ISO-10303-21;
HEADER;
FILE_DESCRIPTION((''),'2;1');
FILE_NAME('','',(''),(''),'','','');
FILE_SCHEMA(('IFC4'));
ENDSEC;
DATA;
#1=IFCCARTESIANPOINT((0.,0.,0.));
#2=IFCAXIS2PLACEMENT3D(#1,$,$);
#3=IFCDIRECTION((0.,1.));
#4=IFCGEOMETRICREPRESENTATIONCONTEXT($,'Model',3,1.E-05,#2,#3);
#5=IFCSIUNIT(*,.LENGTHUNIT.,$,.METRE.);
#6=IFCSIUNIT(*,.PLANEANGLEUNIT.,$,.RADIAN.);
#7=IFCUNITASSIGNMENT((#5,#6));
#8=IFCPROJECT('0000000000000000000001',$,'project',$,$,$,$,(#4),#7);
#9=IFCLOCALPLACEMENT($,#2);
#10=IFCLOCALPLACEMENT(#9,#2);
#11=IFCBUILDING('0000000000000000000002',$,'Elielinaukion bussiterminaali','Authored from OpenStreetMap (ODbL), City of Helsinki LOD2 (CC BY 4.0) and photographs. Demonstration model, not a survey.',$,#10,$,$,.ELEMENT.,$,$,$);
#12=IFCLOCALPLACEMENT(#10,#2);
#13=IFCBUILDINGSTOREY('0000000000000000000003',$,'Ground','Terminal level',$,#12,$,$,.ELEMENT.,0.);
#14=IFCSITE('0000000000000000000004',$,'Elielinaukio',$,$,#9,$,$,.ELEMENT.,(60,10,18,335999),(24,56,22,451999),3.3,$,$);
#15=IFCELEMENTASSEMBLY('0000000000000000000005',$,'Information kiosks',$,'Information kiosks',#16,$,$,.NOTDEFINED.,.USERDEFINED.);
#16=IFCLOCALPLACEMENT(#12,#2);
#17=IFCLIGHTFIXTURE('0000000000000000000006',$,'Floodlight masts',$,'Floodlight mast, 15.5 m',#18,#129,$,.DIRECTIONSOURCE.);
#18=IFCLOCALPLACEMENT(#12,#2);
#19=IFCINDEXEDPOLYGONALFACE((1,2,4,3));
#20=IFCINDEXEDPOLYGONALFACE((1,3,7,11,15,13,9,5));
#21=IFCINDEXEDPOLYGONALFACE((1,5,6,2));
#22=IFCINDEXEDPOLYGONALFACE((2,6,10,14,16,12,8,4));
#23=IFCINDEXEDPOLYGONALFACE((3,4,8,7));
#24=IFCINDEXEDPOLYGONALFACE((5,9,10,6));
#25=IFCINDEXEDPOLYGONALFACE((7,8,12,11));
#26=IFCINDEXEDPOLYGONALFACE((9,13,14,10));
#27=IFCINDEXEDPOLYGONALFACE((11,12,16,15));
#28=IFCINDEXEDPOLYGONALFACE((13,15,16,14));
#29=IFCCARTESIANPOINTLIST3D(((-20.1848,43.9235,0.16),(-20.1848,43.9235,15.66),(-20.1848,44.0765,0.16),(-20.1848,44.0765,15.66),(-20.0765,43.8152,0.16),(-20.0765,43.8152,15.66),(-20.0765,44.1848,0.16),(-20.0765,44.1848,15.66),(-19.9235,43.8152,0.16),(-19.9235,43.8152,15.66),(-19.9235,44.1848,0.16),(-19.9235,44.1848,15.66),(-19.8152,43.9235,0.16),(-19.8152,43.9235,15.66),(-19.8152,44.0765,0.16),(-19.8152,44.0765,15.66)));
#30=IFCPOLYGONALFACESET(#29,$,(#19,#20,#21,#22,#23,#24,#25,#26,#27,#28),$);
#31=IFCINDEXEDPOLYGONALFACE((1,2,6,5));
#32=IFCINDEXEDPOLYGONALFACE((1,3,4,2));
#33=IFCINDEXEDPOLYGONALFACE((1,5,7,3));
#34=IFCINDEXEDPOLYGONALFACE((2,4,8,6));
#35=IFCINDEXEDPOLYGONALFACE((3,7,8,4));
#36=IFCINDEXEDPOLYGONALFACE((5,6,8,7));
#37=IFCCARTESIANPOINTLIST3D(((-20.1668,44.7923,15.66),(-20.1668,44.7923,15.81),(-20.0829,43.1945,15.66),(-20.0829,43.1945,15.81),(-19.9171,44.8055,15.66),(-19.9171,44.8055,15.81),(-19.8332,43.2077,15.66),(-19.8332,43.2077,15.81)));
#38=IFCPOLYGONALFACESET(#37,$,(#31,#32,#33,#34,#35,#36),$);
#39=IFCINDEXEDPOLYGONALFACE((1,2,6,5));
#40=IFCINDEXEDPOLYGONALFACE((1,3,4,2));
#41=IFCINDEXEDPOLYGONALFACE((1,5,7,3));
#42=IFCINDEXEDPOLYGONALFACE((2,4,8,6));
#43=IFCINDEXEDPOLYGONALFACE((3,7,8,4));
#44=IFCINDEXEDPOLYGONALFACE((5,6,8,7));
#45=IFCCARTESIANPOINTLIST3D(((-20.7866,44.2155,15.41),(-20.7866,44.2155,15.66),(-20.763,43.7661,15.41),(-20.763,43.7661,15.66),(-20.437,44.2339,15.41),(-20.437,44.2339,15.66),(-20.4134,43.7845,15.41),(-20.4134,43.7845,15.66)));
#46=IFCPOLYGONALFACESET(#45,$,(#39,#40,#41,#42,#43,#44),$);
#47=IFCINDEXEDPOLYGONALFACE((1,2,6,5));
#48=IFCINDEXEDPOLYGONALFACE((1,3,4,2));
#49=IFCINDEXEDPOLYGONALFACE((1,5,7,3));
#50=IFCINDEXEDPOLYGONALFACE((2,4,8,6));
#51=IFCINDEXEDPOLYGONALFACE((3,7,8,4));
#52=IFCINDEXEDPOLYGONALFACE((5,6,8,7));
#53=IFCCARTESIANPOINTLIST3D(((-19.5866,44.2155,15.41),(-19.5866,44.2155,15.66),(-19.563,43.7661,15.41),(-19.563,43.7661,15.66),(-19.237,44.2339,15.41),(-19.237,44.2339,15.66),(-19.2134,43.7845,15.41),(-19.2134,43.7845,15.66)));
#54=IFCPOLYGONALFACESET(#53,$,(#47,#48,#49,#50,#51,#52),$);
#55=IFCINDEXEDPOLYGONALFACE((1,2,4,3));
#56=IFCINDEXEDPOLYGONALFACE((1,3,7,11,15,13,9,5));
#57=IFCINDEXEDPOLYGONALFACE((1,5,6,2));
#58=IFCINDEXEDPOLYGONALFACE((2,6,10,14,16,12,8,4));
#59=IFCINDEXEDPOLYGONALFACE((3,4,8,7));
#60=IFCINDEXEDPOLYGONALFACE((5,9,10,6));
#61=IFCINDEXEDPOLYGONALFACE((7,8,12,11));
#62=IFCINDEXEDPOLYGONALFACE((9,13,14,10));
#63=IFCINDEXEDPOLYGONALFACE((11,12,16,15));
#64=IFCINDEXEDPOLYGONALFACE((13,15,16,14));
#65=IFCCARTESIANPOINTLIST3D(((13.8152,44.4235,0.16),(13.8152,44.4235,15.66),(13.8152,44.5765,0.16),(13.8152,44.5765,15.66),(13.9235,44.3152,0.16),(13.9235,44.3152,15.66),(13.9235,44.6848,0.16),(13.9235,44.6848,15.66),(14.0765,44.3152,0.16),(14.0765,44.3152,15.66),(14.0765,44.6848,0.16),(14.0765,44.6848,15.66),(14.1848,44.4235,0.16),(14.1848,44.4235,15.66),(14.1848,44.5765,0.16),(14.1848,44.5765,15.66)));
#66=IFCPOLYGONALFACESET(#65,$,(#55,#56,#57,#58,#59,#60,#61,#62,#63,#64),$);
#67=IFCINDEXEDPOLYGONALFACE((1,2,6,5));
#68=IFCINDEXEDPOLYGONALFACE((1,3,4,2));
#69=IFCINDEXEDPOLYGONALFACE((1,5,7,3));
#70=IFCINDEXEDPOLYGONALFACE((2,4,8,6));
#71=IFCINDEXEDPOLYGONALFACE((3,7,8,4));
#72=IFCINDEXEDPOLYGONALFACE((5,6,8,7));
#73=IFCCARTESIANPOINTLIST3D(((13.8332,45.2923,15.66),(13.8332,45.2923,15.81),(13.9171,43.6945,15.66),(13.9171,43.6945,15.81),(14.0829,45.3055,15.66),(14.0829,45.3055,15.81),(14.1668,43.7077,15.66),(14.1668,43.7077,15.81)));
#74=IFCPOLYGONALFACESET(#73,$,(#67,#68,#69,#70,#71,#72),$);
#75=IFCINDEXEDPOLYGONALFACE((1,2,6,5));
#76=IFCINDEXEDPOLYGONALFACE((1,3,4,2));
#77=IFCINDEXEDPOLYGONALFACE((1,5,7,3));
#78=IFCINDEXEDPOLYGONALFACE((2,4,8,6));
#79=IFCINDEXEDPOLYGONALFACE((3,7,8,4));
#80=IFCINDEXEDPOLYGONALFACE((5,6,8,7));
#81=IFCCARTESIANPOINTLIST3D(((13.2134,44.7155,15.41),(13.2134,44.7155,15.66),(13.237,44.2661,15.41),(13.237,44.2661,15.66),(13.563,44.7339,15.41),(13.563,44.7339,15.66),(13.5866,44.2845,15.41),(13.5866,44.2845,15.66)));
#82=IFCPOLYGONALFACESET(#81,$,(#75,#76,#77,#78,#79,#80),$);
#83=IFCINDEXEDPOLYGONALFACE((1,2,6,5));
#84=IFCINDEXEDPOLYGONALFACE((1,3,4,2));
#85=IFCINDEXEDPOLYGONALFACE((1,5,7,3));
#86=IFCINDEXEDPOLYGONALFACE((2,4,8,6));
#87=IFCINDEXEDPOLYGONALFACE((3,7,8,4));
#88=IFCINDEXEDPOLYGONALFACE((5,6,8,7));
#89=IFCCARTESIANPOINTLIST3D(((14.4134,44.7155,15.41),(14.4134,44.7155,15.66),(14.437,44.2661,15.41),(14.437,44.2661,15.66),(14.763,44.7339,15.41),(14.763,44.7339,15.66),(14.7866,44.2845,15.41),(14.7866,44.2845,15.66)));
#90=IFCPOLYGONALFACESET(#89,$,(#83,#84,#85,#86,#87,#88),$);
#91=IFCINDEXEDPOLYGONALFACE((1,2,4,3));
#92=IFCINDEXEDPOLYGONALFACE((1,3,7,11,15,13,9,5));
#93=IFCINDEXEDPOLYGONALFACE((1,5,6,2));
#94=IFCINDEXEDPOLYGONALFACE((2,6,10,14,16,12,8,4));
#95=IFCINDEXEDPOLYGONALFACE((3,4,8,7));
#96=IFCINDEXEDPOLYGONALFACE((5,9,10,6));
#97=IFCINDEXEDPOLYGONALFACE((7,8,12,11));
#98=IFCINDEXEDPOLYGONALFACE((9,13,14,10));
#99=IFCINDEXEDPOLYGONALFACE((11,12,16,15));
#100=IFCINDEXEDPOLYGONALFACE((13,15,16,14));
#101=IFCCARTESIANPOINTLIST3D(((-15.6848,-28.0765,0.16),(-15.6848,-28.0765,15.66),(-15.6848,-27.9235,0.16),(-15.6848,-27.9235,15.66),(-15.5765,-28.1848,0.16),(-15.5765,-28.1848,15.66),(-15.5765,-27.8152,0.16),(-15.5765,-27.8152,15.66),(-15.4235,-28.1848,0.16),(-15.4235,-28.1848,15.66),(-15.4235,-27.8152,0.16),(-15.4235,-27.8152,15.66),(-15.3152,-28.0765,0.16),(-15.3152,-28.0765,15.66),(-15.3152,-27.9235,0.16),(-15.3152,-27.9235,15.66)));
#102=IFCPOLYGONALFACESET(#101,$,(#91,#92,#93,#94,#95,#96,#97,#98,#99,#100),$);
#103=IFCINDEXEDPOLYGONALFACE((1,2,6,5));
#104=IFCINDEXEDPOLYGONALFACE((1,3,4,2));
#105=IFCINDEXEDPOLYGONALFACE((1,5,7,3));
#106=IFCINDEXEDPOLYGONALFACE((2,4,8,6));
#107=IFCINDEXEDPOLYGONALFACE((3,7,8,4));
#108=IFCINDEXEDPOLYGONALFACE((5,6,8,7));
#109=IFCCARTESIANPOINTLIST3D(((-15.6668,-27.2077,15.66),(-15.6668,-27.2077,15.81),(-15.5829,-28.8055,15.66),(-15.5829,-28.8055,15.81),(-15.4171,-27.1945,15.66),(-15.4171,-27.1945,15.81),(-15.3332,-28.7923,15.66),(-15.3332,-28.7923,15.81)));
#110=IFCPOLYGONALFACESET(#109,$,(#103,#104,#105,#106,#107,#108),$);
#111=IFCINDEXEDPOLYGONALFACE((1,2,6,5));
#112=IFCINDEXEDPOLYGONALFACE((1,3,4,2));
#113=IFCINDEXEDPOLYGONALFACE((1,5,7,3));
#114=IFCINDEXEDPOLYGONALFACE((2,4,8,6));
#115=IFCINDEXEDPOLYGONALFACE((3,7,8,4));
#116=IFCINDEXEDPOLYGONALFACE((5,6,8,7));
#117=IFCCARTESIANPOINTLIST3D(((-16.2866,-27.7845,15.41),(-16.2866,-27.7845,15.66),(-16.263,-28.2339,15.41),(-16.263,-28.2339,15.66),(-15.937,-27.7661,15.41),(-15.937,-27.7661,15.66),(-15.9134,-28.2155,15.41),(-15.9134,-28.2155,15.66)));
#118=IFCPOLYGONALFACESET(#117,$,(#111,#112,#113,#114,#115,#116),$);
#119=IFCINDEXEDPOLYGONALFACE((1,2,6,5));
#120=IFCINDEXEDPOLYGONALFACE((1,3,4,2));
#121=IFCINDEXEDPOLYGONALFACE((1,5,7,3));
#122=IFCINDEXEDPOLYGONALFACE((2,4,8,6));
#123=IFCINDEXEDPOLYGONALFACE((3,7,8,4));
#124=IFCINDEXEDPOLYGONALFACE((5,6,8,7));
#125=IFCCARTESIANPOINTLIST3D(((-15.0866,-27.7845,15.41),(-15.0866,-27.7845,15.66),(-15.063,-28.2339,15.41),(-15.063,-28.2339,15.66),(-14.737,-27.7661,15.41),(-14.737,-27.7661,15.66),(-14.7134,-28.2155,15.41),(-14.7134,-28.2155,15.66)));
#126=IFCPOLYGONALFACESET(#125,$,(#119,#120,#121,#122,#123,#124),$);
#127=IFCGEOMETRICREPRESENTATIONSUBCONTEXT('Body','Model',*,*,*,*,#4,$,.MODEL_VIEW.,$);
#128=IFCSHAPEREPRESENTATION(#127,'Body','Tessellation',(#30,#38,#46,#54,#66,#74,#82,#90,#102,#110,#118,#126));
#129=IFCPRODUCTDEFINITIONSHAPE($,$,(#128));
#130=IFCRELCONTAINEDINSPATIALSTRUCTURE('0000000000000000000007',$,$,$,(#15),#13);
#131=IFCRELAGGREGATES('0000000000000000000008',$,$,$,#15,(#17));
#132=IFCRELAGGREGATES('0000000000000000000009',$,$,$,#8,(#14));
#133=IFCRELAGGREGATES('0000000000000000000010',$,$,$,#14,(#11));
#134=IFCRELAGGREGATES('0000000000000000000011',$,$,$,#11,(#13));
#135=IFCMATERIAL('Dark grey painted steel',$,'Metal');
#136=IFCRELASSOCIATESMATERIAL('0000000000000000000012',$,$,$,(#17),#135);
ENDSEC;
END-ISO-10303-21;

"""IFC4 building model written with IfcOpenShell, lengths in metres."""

from ifc_helpers import new_model, si_unit, direction, frame, frame_2d, origin, place, context, subcontext, project, spatial, polyline, rectangle, outline, extrude, material, element, aggregate, save


model = new_model("IFC4")

# Units and contexts
model_context = context("Model", 3, precision=1e-05, world=origin(), true_north=direction((0.0, 1.0)))
body_context = subcontext(model_context, "Body", "Model", "MODEL_VIEW")
ifc_project = project(units=[si_unit("LENGTHUNIT", "METRE"), si_unit("PLANEANGLEUNIT", "RADIAN")], contexts=[model_context])

# Site, building, storey
site_placement = place(None, origin())
site = spatial("IfcSite", under=ifc_project, at=site_placement, Name="Elielinaukio", CompositionType="ELEMENT", RefLatitude=(60, 10, 18, 335999), RefLongitude=(24, 56, 22, 451999), RefElevation=3.3)
building_placement = place(site_placement, origin())
building = spatial("IfcBuilding", under=site, at=building_placement, Name="Elielinaukion bussiterminaali", Description="Authored from OpenStreetMap (ODbL), City of Helsinki LOD2 (CC BY 4.0) and photographs. Demonstration model, not a survey.", CompositionType="ELEMENT")
storey_placement = place(building_placement, origin())
storey = spatial("IfcBuildingStorey", under=building, at=storey_placement, Name="Ground", Description="Terminal level", CompositionType="ELEMENT", Elevation=0.0)

# Shared definitions
ifc_material_1 = material(Name="Dark grey painted steel", Category="Metal")

# Element assembly, light fixture
assembly_1_placement = place(building_placement, origin())
assembly_1 = element("IfcElementAssembly", 1, at=assembly_1_placement, inside=storey, Name="Information kiosks", ObjectType="Information kiosks", AssemblyPlace="NOTDEFINED", PredefinedType="USERDEFINED")
light_fixture_1_placement = place(building_placement, origin())
light_fixture_1 = element("IfcLightFixture", 2, at=light_fixture_1_placement, material=ifc_material_1, Name="Floodlight masts", ObjectType="Floodlight mast, 15.5 m", PredefinedType="DIRECTIONSOURCE", context=body_context, shape_type="SweptSolid", body=[
    extrude(outline(polyline([(-19.8152, 44.0765), (-19.9235, 44.1848), (-20.0765, 44.1848), (-20.1848, 44.0765), (-20.1848, 43.9235), (-20.0765, 43.8152), (-19.9235, 43.8152), (-19.8152, 43.9235), (-19.8152, 44.0765)])), frame((0.0, 0.0, 0.16)), (0.0, 0.0, 1.0), 15.5),
    extrude(rectangle(XDim=1.6, YDim=0.25, at=frame_2d((0.0, 0.0), x_axis=(-0.052408, 0.998626))), frame((-20.0, 44.0, 15.66)), (0.0, 0.0, 1.0), 0.15),
    extrude(rectangle(XDim=0.45, YDim=0.35, at=frame_2d((0.0, 0.0), x_axis=(-0.052408, 0.998626))), frame((-20.6, 44.0, 15.41)), (0.0, 0.0, 1.0), 0.25),
    extrude(rectangle(XDim=0.45, YDim=0.35, at=frame_2d((0.0, 0.0), x_axis=(-0.052408, 0.998626))), frame((-19.4, 44.0, 15.41)), (0.0, 0.0, 1.0), 0.25),
    extrude(outline(polyline([(14.1848, 44.5765), (14.0765, 44.6848), (13.9235, 44.6848), (13.8152, 44.5765), (13.8152, 44.4235), (13.9235, 44.3152), (14.0765, 44.3152), (14.1848, 44.4235), (14.1848, 44.5765)])), frame((0.0, 0.0, 0.16)), (0.0, 0.0, 1.0), 15.5),
    extrude(rectangle(XDim=1.6, YDim=0.25, at=frame_2d((0.0, 0.0), x_axis=(-0.052408, 0.998626))), frame((14.0, 44.5, 15.66)), (0.0, 0.0, 1.0), 0.15),
    extrude(rectangle(XDim=0.45, YDim=0.35, at=frame_2d((0.0, 0.0), x_axis=(-0.052408, 0.998626))), frame((13.4, 44.5, 15.41)), (0.0, 0.0, 1.0), 0.25),
    extrude(rectangle(XDim=0.45, YDim=0.35, at=frame_2d((0.0, 0.0), x_axis=(-0.052408, 0.998626))), frame((14.6, 44.5, 15.41)), (0.0, 0.0, 1.0), 0.25),
    extrude(outline(polyline([(-15.3152, -27.9235), (-15.4235, -27.8152), (-15.5765, -27.8152), (-15.6848, -27.9235), (-15.6848, -28.0765), (-15.5765, -28.1848), (-15.4235, -28.1848), (-15.3152, -28.0765), (-15.3152, -27.9235)])), frame((0.0, 0.0, 0.16)), (0.0, 0.0, 1.0), 15.5),
    extrude(rectangle(XDim=1.6, YDim=0.25, at=frame_2d((0.0, 0.0), x_axis=(-0.052408, 0.998626))), frame((-15.5, -28.0, 15.66)), (0.0, 0.0, 1.0), 0.15),
    extrude(rectangle(XDim=0.45, YDim=0.35, at=frame_2d((0.0, 0.0), x_axis=(-0.052408, 0.998626))), frame((-16.1, -28.0, 15.41)), (0.0, 0.0, 1.0), 0.25),
    extrude(rectangle(XDim=0.45, YDim=0.35, at=frame_2d((0.0, 0.0), x_axis=(-0.052408, 0.998626))), frame((-14.9, -28.0, 15.41)), (0.0, 0.0, 1.0), 0.25),
])

aggregate(assembly_1, [light_fixture_1])

save(model, "model.ifc")
